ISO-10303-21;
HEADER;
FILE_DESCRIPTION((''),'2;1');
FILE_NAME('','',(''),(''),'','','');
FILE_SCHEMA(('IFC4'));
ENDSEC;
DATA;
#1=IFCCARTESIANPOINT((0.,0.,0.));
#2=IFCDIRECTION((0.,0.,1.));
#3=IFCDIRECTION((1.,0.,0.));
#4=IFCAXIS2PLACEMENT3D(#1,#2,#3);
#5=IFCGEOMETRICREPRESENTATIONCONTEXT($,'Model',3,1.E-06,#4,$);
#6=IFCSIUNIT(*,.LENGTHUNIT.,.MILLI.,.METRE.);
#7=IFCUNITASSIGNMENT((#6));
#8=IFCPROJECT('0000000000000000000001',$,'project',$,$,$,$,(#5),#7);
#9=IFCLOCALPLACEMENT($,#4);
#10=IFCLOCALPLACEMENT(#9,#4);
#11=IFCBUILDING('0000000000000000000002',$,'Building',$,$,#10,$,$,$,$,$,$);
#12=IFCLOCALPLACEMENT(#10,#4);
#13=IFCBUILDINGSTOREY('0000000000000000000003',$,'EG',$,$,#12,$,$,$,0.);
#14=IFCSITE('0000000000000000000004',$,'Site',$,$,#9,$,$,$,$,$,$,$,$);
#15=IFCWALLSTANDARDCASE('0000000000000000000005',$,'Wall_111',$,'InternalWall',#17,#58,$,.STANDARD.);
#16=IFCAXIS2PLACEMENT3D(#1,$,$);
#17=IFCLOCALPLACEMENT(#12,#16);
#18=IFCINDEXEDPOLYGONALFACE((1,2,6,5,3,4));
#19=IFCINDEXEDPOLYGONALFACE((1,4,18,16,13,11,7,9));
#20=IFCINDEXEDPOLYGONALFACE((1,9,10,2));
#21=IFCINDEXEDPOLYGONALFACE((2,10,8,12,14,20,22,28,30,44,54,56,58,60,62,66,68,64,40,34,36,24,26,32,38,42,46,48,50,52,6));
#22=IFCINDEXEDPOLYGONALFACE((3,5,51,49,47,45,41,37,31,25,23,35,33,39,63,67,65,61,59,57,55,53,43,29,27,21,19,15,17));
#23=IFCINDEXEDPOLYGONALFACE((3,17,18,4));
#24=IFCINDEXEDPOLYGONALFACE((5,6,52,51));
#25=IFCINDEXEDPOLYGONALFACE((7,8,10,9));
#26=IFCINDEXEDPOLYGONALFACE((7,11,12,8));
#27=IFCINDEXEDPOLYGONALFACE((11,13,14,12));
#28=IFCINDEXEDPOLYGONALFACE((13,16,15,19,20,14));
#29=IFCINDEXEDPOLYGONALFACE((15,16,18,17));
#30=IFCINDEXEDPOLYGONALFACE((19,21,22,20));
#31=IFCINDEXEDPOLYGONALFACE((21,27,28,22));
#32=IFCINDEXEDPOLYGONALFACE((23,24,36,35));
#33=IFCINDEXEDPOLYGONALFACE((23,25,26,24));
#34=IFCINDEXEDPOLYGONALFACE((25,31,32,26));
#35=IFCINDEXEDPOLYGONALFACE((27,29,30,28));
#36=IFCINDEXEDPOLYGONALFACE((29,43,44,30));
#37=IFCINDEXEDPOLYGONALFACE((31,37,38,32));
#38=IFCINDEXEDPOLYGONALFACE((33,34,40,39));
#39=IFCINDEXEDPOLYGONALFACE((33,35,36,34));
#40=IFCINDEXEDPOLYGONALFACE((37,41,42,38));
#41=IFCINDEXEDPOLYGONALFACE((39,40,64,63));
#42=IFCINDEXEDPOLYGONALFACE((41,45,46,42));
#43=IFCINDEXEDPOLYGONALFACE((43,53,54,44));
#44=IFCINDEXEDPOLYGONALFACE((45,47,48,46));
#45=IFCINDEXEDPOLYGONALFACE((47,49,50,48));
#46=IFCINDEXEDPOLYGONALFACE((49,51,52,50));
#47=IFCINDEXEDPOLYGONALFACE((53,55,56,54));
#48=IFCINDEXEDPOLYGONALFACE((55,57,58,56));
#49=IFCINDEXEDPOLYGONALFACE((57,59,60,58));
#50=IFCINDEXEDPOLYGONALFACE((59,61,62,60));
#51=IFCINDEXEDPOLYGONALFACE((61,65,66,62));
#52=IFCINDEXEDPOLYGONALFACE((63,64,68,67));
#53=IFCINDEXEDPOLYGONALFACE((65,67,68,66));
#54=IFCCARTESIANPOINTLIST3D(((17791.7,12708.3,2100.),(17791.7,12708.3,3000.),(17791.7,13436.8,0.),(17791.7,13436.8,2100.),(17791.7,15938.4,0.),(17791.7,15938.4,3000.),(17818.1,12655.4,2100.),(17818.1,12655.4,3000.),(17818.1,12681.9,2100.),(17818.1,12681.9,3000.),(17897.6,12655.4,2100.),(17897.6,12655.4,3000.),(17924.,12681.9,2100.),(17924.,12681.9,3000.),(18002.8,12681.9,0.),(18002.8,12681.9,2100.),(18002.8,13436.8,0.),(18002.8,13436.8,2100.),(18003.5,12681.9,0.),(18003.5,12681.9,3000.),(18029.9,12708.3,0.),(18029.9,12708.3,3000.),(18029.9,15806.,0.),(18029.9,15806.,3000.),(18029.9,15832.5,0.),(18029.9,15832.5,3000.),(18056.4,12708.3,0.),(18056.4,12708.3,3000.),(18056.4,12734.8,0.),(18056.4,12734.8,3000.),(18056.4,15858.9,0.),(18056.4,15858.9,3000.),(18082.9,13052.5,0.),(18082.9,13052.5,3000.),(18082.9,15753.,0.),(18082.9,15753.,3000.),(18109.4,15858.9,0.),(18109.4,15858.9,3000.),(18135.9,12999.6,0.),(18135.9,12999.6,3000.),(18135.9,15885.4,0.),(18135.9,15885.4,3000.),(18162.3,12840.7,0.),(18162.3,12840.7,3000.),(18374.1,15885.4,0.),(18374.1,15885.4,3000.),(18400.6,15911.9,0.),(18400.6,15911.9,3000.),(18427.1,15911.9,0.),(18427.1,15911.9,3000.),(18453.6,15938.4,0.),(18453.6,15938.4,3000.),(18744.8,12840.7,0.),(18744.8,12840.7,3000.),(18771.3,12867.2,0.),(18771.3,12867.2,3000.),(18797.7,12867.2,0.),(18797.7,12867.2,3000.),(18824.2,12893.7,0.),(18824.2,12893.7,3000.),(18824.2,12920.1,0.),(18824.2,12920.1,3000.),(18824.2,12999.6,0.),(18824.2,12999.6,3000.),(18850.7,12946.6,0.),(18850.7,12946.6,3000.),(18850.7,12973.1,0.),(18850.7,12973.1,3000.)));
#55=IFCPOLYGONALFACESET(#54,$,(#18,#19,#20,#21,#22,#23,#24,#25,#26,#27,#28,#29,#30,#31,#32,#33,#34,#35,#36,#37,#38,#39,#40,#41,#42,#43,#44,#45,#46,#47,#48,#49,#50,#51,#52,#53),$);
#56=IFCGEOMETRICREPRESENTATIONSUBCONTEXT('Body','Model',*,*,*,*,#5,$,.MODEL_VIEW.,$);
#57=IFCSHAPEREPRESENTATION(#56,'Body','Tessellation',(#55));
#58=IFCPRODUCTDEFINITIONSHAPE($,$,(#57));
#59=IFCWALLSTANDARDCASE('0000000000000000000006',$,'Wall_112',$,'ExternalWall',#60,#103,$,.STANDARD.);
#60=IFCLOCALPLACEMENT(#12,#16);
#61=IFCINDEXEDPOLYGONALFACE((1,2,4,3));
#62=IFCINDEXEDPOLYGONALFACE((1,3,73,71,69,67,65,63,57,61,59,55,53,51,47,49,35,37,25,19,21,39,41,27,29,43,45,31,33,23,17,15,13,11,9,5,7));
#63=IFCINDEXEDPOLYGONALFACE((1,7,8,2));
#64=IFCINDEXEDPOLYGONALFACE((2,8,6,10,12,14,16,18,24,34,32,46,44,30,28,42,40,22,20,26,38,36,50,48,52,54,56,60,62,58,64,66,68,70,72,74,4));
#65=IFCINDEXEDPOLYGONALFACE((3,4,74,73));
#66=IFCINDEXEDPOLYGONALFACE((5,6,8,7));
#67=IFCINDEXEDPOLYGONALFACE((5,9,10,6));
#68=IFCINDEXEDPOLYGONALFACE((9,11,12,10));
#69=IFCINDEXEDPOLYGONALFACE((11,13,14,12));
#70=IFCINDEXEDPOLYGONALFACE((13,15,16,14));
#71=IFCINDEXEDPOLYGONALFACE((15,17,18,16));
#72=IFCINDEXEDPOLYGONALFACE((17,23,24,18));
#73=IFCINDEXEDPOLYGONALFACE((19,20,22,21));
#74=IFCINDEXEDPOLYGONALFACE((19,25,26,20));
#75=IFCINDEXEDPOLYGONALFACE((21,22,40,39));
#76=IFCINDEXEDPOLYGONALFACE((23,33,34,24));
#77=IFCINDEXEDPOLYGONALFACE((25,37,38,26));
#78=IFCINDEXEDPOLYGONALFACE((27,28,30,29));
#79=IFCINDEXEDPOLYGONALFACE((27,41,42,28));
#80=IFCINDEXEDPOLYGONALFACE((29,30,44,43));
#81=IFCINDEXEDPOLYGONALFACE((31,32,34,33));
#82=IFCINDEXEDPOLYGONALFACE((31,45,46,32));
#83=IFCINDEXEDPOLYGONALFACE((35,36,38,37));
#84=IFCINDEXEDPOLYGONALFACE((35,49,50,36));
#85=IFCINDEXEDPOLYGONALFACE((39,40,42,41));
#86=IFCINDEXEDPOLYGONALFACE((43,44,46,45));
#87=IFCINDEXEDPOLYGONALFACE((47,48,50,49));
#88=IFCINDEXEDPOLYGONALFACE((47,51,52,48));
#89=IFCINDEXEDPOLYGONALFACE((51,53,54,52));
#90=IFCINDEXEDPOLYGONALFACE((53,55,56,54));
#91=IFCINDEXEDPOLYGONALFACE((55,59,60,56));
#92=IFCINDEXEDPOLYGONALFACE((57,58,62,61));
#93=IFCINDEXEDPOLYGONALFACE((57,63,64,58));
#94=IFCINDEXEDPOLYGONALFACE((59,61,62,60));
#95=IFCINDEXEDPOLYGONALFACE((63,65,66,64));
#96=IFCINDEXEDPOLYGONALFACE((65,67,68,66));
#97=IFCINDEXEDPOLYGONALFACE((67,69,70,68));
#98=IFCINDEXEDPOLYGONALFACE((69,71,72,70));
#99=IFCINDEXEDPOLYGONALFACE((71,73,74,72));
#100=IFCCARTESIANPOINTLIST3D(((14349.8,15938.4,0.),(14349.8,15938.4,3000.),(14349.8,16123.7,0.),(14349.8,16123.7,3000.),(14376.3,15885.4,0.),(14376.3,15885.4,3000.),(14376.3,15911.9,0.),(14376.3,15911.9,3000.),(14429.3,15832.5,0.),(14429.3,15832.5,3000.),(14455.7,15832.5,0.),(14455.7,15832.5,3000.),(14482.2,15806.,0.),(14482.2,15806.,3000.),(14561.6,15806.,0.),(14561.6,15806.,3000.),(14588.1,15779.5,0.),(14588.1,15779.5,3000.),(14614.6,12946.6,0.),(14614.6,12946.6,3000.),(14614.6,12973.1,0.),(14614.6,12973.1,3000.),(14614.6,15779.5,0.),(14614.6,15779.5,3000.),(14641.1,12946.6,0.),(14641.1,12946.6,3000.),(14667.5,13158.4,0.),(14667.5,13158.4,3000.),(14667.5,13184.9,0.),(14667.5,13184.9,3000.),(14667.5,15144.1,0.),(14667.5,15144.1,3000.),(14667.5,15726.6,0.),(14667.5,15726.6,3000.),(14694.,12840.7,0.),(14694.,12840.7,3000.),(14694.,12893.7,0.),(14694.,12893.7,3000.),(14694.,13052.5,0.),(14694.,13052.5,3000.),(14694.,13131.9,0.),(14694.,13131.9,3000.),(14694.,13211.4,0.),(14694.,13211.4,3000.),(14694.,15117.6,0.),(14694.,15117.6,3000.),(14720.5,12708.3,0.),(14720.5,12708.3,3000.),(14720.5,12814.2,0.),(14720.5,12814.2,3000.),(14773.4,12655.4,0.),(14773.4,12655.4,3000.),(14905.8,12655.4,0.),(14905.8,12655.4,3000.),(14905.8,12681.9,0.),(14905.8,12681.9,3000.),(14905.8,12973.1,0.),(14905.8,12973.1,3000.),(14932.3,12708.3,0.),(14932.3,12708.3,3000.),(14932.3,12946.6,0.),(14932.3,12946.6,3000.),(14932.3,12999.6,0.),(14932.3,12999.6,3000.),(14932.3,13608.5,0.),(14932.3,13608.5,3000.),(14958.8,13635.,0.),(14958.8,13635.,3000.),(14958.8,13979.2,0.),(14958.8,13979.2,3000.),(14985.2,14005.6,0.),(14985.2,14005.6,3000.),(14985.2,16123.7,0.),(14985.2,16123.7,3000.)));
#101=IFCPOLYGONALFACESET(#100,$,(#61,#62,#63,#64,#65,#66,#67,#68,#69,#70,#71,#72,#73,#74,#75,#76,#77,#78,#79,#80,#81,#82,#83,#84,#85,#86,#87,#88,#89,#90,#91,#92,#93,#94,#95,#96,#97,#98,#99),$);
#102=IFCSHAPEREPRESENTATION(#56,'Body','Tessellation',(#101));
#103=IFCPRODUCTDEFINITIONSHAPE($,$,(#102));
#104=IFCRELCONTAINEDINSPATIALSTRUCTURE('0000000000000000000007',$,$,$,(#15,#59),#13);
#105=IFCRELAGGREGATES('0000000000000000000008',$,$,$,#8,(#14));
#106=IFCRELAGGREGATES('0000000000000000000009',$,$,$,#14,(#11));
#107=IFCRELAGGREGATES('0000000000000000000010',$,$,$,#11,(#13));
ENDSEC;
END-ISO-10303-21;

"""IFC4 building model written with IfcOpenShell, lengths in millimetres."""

from ifc_helpers import new_model, si_unit, frame, origin_with_axes, place, context, subcontext, project, spatial, polyline, rectangle, outline, extrude, element, save


model = new_model("IFC4")

# Units and contexts
model_context = context("Model", 3, precision=1e-06, world=origin_with_axes())
body_context = subcontext(model_context, "Body", "Model", "MODEL_VIEW")
ifc_project = project(units=[si_unit("LENGTHUNIT", "METRE", prefix="MILLI")], contexts=[model_context])

# Site, building, storey
site_placement = place(None, origin_with_axes())
site = spatial("IfcSite", under=ifc_project, at=site_placement, Name="Site")
building_placement = place(site_placement, origin_with_axes())
building = spatial("IfcBuilding", under=site, at=building_placement, Name="Building")
storey_placement = place(building_placement, origin_with_axes())
storey = spatial("IfcBuildingStorey", under=building, at=storey_placement, Name="EG", Elevation=0.0)

# Wall, opening
wall_1_placement = place(storey_placement, origin_with_axes())
wall_1 = element("IfcWallStandardCase", 1, at=wall_1_placement, inside=storey, Name="Wall_111", ObjectType="InternalWall", PredefinedType="STANDARD", context=body_context, shape_type="SweptSolid", body=[
    extrude(outline(polyline([(17818.1, 12655.4, 0.0), (17818.1, 12681.9, 0.0), (17791.7, 12708.3, 0.0), (17791.7, 15938.4, 0.0), (18453.6, 15938.4, 0.0), (18427.1, 15911.9, 0.0), (18400.6, 15911.9, 0.0), (18374.1, 15885.4, 0.0), (18135.9, 15885.4, 0.0), (18109.4, 15858.9, 0.0), (18056.4, 15858.9, 0.0), (18029.9, 15832.5, 0.0), (18029.9, 15806.0, 0.0), (18082.9, 15753.0, 0.0), (18082.9, 13052.5, 0.0), (18135.9, 12999.6, 0.0), (18824.2, 12999.6, 0.0), (18850.7, 12973.1, 0.0), (18850.7, 12946.6, 0.0), (18824.2, 12920.1, 0.0), (18824.2, 12893.7, 0.0), (18797.7, 12867.2, 0.0), (18771.3, 12867.2, 0.0), (18744.8, 12840.7, 0.0), (18162.3, 12840.7, 0.0), (18056.4, 12734.8, 0.0), (18056.4, 12708.3, 0.0), (18029.9, 12708.3, 0.0), (18003.5, 12681.9, 0.0), (17924.0, 12681.9, 0.0), (17897.6, 12655.4, 0.0), (17818.1, 12655.4, 0.0)])), origin_with_axes(), (0.0, 0.0, 1.0), 3000.0),
])
opening_1_placement = place(wall_1_placement, origin_with_axes())
element("IfcOpeningElement", 2, at=opening_1_placement, inside=storey, cuts=wall_1, context=body_context, shape_type="SweptSolid", body=[
    extrude(rectangle(XDim=1440.7, YDim=300.0), frame((17852.8, 12716.5, 0.0), z_axis=(0.0, 0.0, 1.0), x_axis=(0.0, 1.0, 0.0)), (0.0, 0.0, 1.0), 2100.0),
])

# Wall
for number, where, z_axis, x_axis, name in (
    (3, (0.0, 0.0, 0.0), (0.0, 0.0, 1.0), (1.0, 0.0, 0.0), "Wall_112"),
):
    element("IfcWallStandardCase", number, at=place(storey_placement, frame(where, z_axis=z_axis, x_axis=x_axis)), inside=storey, Name=name, ObjectType="ExternalWall", PredefinedType="STANDARD", context=body_context, shape_type="SweptSolid", body=[
        extrude(outline(polyline([(14773.4, 12655.4, 0.0), (14720.5, 12708.3, 0.0), (14720.5, 12814.2, 0.0), (14694.0, 12840.7, 0.0), (14694.0, 12893.7, 0.0), (14641.1, 12946.6, 0.0), (14614.6, 12946.6, 0.0), (14614.6, 12973.1, 0.0), (14694.0, 13052.5, 0.0), (14694.0, 13131.9, 0.0), (14667.5, 13158.4, 0.0), (14667.5, 13184.9, 0.0), (14694.0, 13211.4, 0.0), (14694.0, 15117.6, 0.0), (14667.5, 15144.1, 0.0), (14667.5, 15726.6, 0.0), (14614.6, 15779.5, 0.0), (14588.1, 15779.5, 0.0), (14561.6, 15806.0, 0.0), (14482.2, 15806.0, 0.0), (14455.7, 15832.5, 0.0), (14429.3, 15832.5, 0.0), (14376.3, 15885.4, 0.0), (14376.3, 15911.9, 0.0), (14349.8, 15938.4, 0.0), (14349.8, 16123.7, 0.0), (14985.2, 16123.7, 0.0), (14985.2, 14005.6, 0.0), (14958.8, 13979.2, 0.0), (14958.8, 13635.0, 0.0), (14932.3, 13608.5, 0.0), (14932.3, 12999.6, 0.0), (14905.8, 12973.1, 0.0), (14932.3, 12946.6, 0.0), (14932.3, 12708.3, 0.0), (14905.8, 12681.9, 0.0), (14905.8, 12655.4, 0.0), (14773.4, 12655.4, 0.0)])), origin_with_axes(), (0.0, 0.0, 1.0), 3000.0),
    ])

save(model, "model.ifc")
